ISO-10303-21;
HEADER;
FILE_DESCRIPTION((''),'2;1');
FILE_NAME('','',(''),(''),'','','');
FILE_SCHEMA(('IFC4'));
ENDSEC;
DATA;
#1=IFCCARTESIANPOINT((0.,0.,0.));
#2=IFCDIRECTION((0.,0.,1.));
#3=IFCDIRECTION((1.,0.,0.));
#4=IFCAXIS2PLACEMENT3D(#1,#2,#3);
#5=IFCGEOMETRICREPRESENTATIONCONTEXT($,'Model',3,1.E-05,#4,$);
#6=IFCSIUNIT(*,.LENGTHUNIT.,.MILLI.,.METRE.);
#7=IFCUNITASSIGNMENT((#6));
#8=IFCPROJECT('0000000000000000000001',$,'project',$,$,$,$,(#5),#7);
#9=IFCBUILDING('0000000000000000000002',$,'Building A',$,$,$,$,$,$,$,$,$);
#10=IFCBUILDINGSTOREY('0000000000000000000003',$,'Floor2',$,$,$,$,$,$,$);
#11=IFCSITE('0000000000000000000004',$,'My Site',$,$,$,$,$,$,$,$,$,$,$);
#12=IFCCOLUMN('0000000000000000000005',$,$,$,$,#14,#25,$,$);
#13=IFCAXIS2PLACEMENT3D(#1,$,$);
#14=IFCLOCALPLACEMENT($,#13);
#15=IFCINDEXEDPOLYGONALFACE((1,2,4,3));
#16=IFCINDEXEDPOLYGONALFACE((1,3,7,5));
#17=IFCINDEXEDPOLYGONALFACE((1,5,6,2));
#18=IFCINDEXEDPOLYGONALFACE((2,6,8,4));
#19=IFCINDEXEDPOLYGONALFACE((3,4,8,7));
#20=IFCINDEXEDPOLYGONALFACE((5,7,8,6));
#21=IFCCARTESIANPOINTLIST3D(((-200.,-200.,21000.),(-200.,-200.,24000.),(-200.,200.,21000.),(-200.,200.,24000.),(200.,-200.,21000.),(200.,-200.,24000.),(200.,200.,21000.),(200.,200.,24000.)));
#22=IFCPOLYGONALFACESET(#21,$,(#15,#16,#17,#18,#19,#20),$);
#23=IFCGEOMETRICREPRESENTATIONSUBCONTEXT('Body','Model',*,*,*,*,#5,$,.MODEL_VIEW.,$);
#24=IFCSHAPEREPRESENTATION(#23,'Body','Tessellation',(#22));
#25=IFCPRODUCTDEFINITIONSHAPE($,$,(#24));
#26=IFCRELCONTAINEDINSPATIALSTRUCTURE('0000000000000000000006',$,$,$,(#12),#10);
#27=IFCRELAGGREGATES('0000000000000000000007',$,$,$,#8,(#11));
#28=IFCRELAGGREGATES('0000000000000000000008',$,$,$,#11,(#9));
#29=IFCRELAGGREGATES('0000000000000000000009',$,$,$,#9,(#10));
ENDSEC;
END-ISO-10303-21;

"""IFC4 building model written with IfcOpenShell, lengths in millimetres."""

from ifc_helpers import new_model, si_unit, frame, origin_with_axes, place, context, subcontext, project, spatial, line, indexed_curve, outline, extrude, element, save


model = new_model("IFC4")

# Units and contexts
model_context = context("Model", 3, precision=1e-05, world=origin_with_axes())
body_context = subcontext(model_context, "Body", "Model", "MODEL_VIEW")
ifc_project = project(units=[si_unit("LENGTHUNIT", "METRE", prefix="MILLI")], contexts=[model_context])

# Site, building, storey
site = spatial("IfcSite", under=ifc_project, Name="My Site")
building = spatial("IfcBuilding", under=site, Name="Building A")
storey = spatial("IfcBuildingStorey", under=building, Name="Floor2")

# Column
column_placement = place(None, frame((0.0, 0.0, 21000.0), z_axis=(0.0, 0.0, 1.0), x_axis=(1.0, 0.0, 0.0)))
element("IfcColumn", 1, at=column_placement, inside=storey, context=body_context, shape_type="SweptSolid", body=[
    extrude(outline(indexed_curve([(-200.0, -200.0), (200.0, -200.0), (200.0, 200.0), (-200.0, 200.0)], segments=[line(1, 2, 3, 4, 1)])), origin_with_axes(), (0.0, 0.0, 1.0), 3000.0),
])

save(model, "model.ifc")
